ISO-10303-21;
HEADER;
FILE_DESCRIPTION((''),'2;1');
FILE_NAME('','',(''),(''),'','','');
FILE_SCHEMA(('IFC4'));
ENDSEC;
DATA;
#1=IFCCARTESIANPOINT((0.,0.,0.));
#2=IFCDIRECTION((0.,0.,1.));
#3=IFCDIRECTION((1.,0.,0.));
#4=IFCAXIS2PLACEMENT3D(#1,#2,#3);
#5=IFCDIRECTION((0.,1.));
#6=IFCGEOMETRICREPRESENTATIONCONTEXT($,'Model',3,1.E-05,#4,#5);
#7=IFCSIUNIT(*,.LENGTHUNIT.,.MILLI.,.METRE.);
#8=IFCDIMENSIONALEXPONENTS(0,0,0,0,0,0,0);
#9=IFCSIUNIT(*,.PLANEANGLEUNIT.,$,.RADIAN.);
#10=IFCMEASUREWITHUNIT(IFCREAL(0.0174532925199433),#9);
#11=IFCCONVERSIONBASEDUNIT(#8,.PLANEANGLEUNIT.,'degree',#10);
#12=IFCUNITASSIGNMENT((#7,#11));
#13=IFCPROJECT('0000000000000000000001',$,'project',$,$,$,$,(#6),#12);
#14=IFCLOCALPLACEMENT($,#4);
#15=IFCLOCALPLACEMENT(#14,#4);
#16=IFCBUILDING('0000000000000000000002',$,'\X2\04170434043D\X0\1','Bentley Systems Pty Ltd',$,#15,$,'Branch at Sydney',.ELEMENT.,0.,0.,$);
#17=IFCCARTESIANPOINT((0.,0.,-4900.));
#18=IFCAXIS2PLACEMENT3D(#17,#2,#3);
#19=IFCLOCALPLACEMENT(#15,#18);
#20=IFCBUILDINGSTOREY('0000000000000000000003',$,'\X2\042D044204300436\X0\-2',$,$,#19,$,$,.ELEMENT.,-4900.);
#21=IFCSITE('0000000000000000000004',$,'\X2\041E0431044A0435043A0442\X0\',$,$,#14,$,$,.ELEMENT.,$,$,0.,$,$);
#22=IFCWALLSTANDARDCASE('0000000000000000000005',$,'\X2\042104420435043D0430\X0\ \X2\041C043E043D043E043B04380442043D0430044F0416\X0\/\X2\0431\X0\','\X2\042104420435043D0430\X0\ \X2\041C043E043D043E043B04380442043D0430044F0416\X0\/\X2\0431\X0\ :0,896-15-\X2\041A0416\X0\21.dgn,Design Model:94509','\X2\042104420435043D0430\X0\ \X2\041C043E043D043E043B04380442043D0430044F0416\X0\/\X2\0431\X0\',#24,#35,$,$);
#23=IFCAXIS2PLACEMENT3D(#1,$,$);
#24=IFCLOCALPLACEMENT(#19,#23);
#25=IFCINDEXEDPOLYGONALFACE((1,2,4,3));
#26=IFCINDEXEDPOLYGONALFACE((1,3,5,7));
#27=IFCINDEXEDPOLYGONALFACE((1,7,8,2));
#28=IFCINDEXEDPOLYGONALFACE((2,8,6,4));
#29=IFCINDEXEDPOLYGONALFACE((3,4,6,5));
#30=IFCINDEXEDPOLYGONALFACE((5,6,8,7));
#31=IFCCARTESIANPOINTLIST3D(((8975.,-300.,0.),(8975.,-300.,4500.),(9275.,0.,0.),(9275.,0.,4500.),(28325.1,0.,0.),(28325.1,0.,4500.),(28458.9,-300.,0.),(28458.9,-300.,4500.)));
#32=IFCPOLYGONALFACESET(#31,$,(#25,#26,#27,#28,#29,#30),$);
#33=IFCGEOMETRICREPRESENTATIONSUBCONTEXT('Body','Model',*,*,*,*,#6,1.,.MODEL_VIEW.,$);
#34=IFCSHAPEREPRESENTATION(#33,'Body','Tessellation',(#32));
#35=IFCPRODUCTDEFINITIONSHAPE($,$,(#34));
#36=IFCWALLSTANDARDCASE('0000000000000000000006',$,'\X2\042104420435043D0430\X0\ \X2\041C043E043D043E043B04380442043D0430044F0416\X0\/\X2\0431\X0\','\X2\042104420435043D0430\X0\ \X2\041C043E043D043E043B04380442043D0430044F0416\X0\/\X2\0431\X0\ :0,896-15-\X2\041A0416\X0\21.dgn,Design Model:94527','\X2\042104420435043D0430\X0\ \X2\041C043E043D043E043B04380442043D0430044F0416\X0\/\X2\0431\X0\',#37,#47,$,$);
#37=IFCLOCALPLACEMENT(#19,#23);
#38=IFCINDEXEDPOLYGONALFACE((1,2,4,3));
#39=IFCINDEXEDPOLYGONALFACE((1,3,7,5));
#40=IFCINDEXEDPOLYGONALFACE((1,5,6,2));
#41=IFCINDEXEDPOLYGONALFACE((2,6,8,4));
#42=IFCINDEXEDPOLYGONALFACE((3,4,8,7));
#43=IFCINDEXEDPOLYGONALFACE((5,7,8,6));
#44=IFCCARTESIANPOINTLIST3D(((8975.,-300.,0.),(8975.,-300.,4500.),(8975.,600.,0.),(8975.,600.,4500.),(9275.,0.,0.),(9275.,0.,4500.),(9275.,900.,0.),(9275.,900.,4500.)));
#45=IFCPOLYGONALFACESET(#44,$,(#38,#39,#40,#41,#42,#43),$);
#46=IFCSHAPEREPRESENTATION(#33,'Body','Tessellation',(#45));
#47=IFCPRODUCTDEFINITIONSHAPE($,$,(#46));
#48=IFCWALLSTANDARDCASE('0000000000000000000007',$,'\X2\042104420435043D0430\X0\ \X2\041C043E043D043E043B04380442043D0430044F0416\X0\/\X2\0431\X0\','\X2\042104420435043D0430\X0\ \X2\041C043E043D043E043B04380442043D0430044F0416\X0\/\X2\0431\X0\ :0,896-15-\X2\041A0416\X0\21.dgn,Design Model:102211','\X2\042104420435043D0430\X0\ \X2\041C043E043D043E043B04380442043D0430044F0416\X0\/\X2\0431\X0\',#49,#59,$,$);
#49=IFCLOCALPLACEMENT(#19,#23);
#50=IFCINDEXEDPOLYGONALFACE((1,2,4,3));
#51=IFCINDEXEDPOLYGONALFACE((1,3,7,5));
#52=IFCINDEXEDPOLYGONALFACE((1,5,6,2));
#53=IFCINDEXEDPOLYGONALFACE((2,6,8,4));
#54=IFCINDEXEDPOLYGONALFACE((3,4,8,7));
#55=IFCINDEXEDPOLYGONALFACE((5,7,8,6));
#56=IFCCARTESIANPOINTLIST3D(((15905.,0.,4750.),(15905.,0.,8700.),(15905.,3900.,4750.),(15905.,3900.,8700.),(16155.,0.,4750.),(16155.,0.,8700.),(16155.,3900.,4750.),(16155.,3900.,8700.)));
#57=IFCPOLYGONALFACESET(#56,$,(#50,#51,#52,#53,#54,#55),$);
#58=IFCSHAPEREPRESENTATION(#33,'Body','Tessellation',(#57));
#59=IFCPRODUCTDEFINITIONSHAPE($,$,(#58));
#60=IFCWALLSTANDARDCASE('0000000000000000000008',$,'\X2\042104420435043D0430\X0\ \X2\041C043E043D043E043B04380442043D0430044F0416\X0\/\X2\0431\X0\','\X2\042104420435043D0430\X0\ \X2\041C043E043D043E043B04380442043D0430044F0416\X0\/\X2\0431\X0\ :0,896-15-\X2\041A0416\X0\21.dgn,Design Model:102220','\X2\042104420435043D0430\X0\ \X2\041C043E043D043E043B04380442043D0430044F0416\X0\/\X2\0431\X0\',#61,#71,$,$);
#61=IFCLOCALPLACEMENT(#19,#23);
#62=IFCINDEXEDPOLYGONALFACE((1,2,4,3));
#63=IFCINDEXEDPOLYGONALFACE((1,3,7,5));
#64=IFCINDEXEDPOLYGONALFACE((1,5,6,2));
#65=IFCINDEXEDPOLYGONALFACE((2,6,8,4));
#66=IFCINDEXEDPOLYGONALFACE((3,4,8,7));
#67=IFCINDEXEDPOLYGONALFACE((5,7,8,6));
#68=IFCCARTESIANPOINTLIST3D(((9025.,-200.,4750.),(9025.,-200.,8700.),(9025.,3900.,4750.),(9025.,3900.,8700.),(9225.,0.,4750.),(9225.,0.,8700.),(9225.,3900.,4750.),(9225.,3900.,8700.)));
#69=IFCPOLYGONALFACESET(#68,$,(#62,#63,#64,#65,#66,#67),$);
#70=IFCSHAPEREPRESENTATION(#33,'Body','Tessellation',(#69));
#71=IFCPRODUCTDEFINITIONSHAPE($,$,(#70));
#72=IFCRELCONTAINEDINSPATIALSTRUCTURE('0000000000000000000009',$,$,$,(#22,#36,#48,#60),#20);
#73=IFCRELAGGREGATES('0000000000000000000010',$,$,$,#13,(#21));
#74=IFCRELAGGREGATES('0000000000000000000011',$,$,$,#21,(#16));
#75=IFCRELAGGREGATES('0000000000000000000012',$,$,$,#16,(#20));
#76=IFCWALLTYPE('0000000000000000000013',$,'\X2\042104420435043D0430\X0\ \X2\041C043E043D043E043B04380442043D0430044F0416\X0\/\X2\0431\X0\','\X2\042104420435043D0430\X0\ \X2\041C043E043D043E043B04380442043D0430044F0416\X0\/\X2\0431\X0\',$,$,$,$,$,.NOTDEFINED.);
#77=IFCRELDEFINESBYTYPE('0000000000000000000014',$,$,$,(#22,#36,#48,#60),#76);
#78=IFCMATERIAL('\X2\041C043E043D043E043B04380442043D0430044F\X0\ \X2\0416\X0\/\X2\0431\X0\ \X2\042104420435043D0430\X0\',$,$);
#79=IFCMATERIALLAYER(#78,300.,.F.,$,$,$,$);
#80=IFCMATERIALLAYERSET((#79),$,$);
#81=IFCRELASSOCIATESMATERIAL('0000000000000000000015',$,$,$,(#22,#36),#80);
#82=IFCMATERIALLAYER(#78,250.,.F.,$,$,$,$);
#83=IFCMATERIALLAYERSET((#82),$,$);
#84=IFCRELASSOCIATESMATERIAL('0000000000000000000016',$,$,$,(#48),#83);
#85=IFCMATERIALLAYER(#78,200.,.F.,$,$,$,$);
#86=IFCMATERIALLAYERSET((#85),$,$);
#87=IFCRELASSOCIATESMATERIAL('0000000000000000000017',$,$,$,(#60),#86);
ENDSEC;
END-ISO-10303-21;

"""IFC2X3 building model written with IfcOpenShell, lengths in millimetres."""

from ifc_helpers import new_model, entity, si_unit, converted_unit, direction, frame, frame_2d, origin_with_axes, place, context, subcontext, project, spatial, polyline, rectangle, outline, extrude, material, layer, layer_set, layer_usage, type_object, element, save


model = new_model("IFC2X3")

# Units and contexts
model_context = context("Model", 3, precision=1e-05, world=origin_with_axes(), true_north=direction((0.0, 1.0)))
body_context = subcontext(model_context, "Body", "Model", "MODEL_VIEW", scale=1.0)
ifc_project = project(units=[si_unit("LENGTHUNIT", "METRE", prefix="MILLI"), converted_unit("PLANEANGLEUNIT", "degree", entity("IfcReal", 0.0174532925199433), si_unit("PLANEANGLEUNIT", "RADIAN"), dimensions=[0, 0, 0, 0, 0, 0, 0])], contexts=[model_context])

# Site, building, storey
site_placement = place(None, origin_with_axes())
site = spatial("IfcSite", under=ifc_project, at=site_placement, Name="Объект", CompositionType="ELEMENT", RefElevation=0.0)
building_placement = place(site_placement, origin_with_axes())
building = spatial("IfcBuilding", under=site, at=building_placement, Name="Здн1", Description="Bentley Systems Pty Ltd", LongName="Branch at Sydney", CompositionType="ELEMENT", ElevationOfRefHeight=0.0, ElevationOfTerrain=0.0)
storey_placement = place(building_placement, frame((0.0, 0.0, -4900.0), z_axis=(0.0, 0.0, 1.0), x_axis=(1.0, 0.0, 0.0)))
storey = spatial("IfcBuildingStorey", under=building, at=storey_placement, Name="Этаж-2", CompositionType="ELEMENT", Elevation=-4900.0)

# Walls
ifc_material = material(Name="Монолитная Ж/б Стена")
ifc_layer_1 = layer(ifc_material, 300.0, ventilated=False)
ifc_layer_set_1 = layer_set([ifc_layer_1])
ifc_layer_usage_1 = layer_usage(ifc_layer_set_1, "AXIS2", "POSITIVE", 0.0)
wall_type = type_object("IfcWallType", Name="Стена МонолитнаяЖ/б", Description="Стена МонолитнаяЖ/б", PredefinedType="NOTDEFINED")
wall_1_placement = place(storey_placement, frame((8975.0, -300.0, 0.0), z_axis=(0.0, 0.0, 1.0), x_axis=(1.0, 0.0, 0.0)))
element("IfcWallStandardCase", 1, at=wall_1_placement, inside=storey, type_object=wall_type, material=ifc_layer_usage_1, Name="Стена МонолитнаяЖ/б", Description="Стена МонолитнаяЖ/б :0,896-15-КЖ21.dgn,Design Model:94509", ObjectType="Стена МонолитнаяЖ/б", context=body_context, shape_type="SweptSolid", body=[
    extrude(outline(polyline([(19350.1, 300.0), (300.0, 300.0), (0.0, 0.0), (19483.9, 0.0), (19350.1, 300.0)])), origin_with_axes(), (0.0, 0.0, 1.0), 4500.0),
])
wall_2_placement = place(storey_placement, frame((8975.0, 600.0, 0.0), z_axis=(0.0, 0.0, 1.0), x_axis=(0.0, -1.0, 0.0)))
element("IfcWallStandardCase", 2, at=wall_2_placement, inside=storey, type_object=wall_type, material=ifc_layer_usage_1, Name="Стена МонолитнаяЖ/б", Description="Стена МонолитнаяЖ/б :0,896-15-КЖ21.dgn,Design Model:94527", ObjectType="Стена МонолитнаяЖ/б", context=body_context, shape_type="SweptSolid", body=[
    extrude(outline(polyline([(600.0, 300.0), (-300.0, 300.0), (0.0, 0.0), (900.0, 0.0), (600.0, 300.0)])), origin_with_axes(), (0.0, 0.0, 1.0), 4500.0),
])
ifc_layer_2 = layer(ifc_material, 250.0, ventilated=False)
ifc_layer_set_2 = layer_set([ifc_layer_2])
ifc_layer_usage_2 = layer_usage(ifc_layer_set_2, "AXIS2", "POSITIVE", 0.0)
wall_3_placement = place(storey_placement, frame((15905.0, 0.0, 4750.0), z_axis=(0.0, 0.0, 1.0), x_axis=(0.0, 1.0, 0.0)))
element("IfcWallStandardCase", 3, at=wall_3_placement, inside=storey, type_object=wall_type, material=ifc_layer_usage_2, Name="Стена МонолитнаяЖ/б", Description="Стена МонолитнаяЖ/б :0,896-15-КЖ21.dgn,Design Model:102211", ObjectType="Стена МонолитнаяЖ/б", context=body_context, shape_type="SweptSolid", body=[
    extrude(rectangle(XDim=3900.0, YDim=250.0, at=frame_2d((1950.0, -125.0), x_axis=(1.0, 0.0))), origin_with_axes(), (0.0, 0.0, 1.0), 3950.0),
])
ifc_layer_3 = layer(ifc_material, 200.0, ventilated=False)
ifc_layer_set_3 = layer_set([ifc_layer_3])
ifc_layer_usage_3 = layer_usage(ifc_layer_set_3, "AXIS2", "POSITIVE", 0.0)
wall_4_placement = place(storey_placement, frame((9025.0, -200.0, 4750.0), z_axis=(0.0, 0.0, 1.0), x_axis=(0.0, 1.0, 0.0)))
element("IfcWallStandardCase", 4, at=wall_4_placement, inside=storey, type_object=wall_type, material=ifc_layer_usage_3, Name="Стена МонолитнаяЖ/б", Description="Стена МонолитнаяЖ/б :0,896-15-КЖ21.dgn,Design Model:102220", ObjectType="Стена МонолитнаяЖ/б", context=body_context, shape_type="SweptSolid", body=[
    extrude(outline(polyline([(0.0, 0.0), (200.0, -200.0), (4100.0, -200.0), (4100.0, 0.0), (0.0, 0.0)])), origin_with_axes(), (0.0, 0.0, 1.0), 3950.0),
])

save(model, "model.ifc")
